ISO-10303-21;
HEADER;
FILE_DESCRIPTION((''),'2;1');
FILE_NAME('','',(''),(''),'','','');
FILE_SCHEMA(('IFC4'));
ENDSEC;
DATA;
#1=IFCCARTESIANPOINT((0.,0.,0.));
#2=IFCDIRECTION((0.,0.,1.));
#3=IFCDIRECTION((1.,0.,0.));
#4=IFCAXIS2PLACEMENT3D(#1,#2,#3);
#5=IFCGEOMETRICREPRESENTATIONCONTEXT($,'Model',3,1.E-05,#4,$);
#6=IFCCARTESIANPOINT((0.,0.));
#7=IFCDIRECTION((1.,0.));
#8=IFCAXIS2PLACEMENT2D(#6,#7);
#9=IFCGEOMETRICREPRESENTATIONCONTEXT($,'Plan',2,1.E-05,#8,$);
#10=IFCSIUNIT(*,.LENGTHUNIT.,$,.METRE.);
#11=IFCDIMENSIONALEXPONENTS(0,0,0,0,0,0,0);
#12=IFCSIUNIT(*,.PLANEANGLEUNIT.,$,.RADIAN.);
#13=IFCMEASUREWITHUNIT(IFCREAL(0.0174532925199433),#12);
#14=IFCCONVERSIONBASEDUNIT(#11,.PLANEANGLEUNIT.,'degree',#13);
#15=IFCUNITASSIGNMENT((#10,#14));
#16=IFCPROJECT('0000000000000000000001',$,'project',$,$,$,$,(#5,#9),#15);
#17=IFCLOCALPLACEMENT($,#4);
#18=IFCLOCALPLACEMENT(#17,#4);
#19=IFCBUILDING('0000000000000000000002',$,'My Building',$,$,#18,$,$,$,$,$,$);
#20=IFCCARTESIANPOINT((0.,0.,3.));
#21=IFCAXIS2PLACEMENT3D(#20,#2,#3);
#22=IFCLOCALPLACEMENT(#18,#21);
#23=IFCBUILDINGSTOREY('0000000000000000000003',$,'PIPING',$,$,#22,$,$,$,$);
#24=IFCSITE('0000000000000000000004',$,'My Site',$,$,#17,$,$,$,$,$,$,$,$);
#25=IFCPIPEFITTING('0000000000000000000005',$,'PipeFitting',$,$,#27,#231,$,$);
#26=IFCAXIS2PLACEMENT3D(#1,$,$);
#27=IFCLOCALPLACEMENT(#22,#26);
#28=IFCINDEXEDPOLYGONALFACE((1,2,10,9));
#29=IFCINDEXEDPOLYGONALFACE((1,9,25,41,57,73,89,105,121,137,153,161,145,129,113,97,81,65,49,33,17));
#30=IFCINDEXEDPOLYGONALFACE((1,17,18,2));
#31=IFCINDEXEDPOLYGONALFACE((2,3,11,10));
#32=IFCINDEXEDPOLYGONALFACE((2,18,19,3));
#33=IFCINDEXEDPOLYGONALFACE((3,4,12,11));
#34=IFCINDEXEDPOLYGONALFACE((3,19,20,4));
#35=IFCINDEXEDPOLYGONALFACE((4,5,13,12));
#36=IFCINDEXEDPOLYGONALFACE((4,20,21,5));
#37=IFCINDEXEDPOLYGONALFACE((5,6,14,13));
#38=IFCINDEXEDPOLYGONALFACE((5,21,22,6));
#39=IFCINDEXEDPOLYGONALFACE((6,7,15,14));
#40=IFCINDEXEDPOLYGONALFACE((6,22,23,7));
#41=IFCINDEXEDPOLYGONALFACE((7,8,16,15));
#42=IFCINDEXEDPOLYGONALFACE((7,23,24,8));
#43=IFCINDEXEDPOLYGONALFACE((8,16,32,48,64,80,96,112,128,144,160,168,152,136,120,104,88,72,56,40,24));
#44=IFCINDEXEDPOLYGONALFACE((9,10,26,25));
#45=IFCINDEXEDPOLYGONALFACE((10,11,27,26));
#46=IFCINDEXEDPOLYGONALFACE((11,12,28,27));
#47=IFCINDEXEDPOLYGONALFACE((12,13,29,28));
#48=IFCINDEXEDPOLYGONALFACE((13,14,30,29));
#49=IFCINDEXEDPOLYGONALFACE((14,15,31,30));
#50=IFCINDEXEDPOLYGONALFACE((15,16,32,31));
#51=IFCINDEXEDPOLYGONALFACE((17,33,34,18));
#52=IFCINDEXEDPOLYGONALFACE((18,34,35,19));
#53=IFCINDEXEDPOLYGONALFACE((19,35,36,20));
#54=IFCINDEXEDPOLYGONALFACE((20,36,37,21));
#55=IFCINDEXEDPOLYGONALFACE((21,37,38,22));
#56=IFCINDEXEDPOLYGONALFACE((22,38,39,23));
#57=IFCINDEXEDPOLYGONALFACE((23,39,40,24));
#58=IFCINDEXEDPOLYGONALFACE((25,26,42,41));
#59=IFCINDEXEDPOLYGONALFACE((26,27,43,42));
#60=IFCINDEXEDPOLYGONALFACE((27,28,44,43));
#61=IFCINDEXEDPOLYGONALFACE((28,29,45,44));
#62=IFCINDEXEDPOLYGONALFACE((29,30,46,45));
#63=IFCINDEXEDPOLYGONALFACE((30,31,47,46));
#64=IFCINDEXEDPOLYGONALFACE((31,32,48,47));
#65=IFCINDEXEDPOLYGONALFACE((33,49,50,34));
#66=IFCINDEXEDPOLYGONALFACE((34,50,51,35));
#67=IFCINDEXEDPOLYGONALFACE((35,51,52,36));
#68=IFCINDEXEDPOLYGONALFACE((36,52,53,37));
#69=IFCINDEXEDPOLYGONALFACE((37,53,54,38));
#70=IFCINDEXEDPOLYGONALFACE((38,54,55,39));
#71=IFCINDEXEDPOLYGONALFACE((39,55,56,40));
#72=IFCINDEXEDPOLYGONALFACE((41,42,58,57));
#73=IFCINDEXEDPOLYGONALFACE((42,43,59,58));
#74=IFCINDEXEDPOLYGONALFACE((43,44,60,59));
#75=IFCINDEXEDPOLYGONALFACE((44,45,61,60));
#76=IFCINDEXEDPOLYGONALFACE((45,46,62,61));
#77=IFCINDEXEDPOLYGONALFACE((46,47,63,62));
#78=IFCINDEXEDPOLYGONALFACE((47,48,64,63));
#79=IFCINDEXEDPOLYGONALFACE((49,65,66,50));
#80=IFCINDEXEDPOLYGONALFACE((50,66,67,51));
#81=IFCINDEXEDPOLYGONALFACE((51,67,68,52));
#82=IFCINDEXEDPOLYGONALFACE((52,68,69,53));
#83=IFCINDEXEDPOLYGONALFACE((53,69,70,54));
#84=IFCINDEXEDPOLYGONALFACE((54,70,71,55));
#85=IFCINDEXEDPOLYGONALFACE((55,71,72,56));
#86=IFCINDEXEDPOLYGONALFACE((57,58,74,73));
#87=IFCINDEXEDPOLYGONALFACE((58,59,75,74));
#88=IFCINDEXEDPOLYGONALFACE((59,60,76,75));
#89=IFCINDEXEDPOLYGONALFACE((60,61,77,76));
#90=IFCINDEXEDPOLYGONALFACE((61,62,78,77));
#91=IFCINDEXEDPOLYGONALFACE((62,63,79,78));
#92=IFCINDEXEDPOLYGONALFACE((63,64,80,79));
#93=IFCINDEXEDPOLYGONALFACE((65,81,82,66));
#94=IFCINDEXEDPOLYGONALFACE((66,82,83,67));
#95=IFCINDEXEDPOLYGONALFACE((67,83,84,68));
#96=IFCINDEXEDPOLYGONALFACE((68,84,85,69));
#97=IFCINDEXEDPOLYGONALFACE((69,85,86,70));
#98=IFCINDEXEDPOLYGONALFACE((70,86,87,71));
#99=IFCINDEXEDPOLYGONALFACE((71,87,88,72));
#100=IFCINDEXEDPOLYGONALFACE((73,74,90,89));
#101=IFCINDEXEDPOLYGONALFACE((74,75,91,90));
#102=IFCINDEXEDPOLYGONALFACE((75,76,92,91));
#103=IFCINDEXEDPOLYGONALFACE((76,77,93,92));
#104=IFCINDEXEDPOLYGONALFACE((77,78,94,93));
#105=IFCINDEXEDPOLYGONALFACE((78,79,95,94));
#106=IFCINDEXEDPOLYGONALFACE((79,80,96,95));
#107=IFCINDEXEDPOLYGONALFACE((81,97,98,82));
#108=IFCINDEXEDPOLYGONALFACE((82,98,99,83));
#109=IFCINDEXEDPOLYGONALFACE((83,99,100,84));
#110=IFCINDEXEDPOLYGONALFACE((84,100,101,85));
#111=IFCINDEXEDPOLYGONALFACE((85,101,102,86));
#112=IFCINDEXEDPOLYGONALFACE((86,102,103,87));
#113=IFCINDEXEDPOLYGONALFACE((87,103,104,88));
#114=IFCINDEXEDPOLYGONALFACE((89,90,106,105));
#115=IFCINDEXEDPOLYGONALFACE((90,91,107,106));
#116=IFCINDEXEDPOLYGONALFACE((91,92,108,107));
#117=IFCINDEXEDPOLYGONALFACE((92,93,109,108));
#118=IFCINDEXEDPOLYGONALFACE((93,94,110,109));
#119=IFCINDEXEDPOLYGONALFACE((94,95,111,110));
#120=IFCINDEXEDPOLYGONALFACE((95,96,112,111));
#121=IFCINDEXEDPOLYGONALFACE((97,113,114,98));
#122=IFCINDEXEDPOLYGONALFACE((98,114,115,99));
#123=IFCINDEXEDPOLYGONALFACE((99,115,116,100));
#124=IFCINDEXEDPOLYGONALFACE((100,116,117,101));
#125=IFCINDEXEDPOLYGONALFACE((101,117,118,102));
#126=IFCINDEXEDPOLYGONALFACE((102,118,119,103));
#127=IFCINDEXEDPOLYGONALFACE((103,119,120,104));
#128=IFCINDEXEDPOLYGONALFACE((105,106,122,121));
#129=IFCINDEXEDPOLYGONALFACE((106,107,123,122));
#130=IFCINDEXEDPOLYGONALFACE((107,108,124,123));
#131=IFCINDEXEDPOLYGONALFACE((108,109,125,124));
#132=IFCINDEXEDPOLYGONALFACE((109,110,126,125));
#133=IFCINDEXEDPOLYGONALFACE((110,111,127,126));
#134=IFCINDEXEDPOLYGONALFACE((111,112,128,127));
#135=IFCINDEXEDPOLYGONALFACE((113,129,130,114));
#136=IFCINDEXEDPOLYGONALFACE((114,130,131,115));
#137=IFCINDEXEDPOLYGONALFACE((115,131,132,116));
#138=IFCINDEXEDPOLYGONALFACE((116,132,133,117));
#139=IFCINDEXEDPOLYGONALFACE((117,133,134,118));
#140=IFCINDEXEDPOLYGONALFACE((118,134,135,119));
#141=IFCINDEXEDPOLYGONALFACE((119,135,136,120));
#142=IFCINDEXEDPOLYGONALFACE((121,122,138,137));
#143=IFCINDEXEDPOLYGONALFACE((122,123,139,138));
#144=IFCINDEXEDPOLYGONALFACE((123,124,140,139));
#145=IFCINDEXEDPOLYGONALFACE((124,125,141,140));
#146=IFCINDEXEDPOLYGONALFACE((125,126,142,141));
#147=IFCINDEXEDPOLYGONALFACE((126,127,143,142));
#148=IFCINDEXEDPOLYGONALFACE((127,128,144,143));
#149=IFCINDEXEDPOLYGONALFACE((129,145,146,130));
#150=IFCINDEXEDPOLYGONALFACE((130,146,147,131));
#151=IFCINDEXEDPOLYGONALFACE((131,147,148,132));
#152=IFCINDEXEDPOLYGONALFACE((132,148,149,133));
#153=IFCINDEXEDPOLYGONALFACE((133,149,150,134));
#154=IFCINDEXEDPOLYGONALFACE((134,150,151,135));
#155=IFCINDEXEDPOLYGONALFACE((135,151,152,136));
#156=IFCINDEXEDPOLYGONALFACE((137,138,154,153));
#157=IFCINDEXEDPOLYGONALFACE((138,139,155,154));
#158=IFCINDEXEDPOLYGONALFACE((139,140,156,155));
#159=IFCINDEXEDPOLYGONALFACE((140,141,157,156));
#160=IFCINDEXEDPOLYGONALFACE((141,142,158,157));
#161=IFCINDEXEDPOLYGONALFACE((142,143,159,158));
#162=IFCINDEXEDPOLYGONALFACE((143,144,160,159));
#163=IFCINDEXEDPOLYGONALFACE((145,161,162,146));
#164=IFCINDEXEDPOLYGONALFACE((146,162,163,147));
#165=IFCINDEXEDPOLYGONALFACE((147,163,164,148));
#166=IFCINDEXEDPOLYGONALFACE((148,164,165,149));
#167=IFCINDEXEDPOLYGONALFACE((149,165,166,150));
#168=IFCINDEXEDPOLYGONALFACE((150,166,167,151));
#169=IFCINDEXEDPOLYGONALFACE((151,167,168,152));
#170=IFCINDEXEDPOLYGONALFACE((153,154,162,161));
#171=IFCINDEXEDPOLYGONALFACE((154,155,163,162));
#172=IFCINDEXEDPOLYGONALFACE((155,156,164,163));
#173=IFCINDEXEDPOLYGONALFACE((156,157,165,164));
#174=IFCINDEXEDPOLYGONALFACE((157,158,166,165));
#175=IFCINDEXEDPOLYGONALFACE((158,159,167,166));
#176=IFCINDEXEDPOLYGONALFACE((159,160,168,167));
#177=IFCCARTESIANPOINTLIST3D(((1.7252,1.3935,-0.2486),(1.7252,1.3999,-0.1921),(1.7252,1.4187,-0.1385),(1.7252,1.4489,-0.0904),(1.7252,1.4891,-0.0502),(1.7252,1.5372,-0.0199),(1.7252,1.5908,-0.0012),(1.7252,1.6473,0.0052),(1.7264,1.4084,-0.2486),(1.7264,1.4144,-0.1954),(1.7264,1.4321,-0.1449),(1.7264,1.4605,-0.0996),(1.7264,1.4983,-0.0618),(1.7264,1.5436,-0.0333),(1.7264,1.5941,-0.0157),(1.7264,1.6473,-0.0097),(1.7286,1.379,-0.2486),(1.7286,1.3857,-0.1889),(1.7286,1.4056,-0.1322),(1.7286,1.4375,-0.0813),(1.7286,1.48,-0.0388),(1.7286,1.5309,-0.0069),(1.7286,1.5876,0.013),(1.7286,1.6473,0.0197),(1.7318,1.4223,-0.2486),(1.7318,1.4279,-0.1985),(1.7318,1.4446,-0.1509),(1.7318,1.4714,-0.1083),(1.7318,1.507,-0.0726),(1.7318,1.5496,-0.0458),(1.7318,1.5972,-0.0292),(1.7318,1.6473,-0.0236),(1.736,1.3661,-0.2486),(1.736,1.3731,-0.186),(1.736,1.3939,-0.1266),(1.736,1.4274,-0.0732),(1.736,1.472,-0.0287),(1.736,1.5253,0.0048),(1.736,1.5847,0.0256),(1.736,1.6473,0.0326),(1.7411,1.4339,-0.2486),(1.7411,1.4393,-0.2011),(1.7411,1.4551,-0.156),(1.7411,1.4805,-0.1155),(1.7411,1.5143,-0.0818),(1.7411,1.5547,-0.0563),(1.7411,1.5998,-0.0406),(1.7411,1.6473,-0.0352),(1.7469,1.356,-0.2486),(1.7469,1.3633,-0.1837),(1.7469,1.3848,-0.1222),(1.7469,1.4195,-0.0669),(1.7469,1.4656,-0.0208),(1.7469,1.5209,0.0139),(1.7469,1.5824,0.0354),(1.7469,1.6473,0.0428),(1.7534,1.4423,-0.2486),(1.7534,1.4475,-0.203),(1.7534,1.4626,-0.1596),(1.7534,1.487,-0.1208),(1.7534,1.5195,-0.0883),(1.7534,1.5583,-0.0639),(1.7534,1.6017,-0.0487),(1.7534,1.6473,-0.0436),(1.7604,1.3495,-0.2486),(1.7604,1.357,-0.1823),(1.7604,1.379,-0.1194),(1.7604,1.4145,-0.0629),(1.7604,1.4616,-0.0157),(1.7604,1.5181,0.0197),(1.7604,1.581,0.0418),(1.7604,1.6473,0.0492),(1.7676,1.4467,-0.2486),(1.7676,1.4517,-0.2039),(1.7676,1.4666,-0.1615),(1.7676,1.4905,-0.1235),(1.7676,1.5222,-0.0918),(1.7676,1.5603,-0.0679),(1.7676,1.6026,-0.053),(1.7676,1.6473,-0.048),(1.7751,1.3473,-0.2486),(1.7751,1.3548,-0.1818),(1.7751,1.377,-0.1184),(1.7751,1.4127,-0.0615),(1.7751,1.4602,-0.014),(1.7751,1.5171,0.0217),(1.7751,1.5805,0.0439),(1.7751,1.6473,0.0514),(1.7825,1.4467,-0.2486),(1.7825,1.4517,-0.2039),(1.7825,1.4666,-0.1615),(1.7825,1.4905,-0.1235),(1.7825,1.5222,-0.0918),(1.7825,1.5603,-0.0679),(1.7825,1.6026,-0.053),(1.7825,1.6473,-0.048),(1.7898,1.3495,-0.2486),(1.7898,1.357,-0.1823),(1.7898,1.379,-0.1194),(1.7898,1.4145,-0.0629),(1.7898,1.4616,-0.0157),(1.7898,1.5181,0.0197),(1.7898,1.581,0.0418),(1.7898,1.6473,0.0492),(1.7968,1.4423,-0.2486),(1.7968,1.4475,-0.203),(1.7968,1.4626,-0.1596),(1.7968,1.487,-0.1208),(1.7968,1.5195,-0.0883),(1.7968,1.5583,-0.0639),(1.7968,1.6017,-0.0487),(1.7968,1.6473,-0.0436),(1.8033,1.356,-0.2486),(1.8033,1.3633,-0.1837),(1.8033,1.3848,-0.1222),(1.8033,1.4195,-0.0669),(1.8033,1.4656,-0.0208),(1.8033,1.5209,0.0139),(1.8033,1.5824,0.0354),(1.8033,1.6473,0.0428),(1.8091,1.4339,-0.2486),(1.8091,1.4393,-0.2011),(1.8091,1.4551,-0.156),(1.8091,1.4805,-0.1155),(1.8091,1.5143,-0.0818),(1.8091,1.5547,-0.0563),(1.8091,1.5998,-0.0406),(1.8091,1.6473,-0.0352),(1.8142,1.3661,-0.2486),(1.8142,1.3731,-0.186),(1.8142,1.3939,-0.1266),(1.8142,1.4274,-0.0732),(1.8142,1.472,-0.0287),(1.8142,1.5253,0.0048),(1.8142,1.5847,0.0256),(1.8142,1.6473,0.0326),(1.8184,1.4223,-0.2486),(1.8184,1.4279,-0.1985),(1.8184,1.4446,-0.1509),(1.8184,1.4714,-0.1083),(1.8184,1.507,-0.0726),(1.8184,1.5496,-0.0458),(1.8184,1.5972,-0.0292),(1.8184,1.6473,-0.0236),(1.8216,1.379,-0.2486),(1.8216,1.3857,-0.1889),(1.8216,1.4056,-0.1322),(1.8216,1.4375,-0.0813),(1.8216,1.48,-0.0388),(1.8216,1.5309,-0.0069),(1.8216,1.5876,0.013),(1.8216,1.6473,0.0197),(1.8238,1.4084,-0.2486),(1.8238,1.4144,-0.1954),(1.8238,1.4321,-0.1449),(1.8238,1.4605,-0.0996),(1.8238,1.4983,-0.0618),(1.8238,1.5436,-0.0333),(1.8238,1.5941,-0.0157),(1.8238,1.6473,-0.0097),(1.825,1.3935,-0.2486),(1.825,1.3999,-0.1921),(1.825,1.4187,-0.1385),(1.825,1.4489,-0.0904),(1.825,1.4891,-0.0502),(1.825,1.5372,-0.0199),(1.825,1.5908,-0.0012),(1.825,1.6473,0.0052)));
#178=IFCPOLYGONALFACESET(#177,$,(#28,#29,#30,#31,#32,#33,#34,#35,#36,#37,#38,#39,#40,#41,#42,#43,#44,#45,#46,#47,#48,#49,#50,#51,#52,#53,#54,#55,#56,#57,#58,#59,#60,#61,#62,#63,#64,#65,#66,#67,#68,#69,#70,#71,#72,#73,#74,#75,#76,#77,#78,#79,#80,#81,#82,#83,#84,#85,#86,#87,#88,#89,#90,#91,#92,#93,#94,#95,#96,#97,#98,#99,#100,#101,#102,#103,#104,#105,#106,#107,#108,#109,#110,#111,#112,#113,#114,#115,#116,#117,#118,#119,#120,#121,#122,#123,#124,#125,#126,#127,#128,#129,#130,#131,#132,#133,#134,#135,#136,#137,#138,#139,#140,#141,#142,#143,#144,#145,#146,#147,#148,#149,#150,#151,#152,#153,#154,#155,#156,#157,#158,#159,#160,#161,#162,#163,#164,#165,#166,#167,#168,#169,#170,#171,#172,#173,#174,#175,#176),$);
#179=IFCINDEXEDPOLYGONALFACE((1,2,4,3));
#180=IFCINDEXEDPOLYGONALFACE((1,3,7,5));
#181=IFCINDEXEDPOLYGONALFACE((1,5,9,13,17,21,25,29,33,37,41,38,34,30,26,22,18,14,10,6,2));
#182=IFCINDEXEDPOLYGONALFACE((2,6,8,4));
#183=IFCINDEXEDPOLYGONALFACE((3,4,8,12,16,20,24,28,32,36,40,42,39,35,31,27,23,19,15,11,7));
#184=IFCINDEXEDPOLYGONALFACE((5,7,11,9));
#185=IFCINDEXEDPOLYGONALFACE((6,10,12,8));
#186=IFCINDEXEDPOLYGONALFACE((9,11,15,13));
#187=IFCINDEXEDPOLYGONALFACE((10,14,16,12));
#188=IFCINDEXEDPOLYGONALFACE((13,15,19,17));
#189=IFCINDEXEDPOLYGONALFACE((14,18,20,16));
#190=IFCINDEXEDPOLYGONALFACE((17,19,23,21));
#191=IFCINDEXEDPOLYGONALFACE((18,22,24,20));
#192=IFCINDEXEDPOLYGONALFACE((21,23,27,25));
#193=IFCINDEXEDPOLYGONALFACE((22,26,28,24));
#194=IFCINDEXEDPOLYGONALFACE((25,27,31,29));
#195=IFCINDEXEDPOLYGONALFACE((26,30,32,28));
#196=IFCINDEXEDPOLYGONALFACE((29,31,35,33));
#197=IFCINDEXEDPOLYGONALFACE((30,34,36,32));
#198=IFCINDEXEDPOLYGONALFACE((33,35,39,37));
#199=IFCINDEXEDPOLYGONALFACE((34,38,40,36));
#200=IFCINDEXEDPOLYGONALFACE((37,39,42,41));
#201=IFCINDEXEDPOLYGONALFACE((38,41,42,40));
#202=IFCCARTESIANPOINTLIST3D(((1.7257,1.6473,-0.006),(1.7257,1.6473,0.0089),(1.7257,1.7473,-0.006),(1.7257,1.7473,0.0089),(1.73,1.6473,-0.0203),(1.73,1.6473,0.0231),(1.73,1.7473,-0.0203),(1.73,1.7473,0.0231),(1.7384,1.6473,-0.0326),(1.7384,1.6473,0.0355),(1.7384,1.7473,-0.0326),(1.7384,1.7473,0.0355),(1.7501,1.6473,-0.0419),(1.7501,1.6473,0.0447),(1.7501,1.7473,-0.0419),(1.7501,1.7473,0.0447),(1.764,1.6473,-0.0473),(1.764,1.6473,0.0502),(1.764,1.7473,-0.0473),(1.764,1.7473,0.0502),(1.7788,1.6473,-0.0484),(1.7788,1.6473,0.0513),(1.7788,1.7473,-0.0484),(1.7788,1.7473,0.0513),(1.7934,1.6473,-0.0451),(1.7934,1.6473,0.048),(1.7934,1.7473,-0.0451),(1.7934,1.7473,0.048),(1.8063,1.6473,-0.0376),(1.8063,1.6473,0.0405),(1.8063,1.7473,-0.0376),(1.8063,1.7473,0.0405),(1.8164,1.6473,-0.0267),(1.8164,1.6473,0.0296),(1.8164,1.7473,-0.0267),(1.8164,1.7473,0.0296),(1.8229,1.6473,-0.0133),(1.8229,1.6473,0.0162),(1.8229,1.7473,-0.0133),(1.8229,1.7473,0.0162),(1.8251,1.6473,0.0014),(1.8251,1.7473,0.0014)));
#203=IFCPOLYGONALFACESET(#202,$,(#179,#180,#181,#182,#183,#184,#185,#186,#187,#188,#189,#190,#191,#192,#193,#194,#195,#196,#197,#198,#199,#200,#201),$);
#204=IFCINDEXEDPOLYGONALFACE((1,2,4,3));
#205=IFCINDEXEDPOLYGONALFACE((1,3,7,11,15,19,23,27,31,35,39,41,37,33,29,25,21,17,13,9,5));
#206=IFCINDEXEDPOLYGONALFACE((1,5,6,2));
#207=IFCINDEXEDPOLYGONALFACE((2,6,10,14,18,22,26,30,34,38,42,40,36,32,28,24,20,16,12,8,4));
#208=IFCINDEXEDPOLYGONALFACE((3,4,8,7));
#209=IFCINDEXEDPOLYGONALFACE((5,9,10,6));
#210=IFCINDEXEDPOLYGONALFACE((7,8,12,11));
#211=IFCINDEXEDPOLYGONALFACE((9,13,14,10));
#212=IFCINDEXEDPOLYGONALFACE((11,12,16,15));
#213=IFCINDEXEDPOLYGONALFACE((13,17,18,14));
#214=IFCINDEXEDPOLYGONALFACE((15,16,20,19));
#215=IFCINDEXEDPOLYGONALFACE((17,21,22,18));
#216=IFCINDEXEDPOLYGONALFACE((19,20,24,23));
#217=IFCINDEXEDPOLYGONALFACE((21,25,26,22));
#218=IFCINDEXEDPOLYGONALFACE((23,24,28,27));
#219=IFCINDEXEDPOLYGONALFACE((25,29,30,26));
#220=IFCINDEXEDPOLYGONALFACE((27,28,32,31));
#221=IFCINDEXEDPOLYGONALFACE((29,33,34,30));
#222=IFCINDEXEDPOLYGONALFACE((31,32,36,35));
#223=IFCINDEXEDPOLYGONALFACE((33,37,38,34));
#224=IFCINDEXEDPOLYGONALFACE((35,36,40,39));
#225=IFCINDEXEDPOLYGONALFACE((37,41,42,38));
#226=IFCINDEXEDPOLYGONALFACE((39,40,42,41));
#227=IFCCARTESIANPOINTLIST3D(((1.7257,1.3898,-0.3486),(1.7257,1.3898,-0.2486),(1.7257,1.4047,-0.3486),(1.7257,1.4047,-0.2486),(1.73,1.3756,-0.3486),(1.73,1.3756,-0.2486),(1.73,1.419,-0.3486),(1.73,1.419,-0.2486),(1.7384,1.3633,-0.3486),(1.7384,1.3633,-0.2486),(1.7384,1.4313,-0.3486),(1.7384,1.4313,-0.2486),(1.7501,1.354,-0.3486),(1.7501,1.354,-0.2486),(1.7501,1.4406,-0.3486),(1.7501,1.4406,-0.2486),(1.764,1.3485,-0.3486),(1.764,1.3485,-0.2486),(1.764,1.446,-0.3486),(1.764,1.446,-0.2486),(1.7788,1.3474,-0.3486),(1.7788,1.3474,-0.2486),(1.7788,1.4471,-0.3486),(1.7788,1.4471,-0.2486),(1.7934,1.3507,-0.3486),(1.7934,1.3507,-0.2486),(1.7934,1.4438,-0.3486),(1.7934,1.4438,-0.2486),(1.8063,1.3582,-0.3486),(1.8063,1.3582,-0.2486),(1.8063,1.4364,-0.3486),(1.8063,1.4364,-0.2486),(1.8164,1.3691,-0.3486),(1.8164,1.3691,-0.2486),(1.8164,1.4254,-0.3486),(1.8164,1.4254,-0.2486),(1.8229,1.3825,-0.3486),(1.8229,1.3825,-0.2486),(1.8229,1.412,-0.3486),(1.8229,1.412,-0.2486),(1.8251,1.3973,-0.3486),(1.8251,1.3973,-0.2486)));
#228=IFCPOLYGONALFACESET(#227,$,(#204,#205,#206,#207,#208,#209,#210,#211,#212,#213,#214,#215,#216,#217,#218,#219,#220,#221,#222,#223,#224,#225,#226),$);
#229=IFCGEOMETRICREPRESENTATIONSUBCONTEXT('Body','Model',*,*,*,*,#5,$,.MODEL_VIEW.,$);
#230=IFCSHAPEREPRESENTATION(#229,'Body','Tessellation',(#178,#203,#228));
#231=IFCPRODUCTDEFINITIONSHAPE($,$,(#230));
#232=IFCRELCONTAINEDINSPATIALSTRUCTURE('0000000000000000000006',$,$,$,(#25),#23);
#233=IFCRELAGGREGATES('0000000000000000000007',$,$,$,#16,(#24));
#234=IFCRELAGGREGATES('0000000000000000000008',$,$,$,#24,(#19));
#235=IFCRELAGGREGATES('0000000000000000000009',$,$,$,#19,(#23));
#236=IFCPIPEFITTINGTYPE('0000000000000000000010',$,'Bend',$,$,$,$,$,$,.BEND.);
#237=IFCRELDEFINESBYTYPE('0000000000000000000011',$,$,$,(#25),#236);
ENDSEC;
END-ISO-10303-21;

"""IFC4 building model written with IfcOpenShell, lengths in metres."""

from ifc_helpers import new_model, entity, si_unit, converted_unit, frame, origin_with_axes, origin_2d_with_axis, place, context, subcontext, project, spatial, circle, extrude, source, transform, mapped, type_object, type_shapes, element, save


model = new_model("IFC4")

# Units and contexts
model_context = context("Model", 3, precision=1e-05, world=origin_with_axes())
plan_context = context("Plan", 2, precision=1e-05, world=origin_2d_with_axis())
body_context = subcontext(model_context, "Body", "Model", "MODEL_VIEW")
ifc_project = project(units=[si_unit("LENGTHUNIT", "METRE"), converted_unit("PLANEANGLEUNIT", "degree", entity("IfcReal", 0.0174532925199433), si_unit("PLANEANGLEUNIT", "RADIAN"), dimensions=[0, 0, 0, 0, 0, 0, 0])], contexts=[model_context, plan_context])

# Site, building, storey
site_placement = place(None, origin_with_axes())
site = spatial("IfcSite", under=ifc_project, at=site_placement, Name="My Site")
building_placement = place(site_placement, origin_with_axes())
building = spatial("IfcBuilding", under=site, at=building_placement, Name="My Building")
storey_placement = place(building_placement, frame((0.0, 0.0, 3.0), z_axis=(0.0, 0.0, 1.0), x_axis=(1.0, 0.0, 0.0)))
storey = spatial("IfcBuildingStorey", under=building, at=storey_placement, Name="PIPING")

# Pipe fitting
pipe_fitting_type = type_object("IfcPipeFittingType", Name="Bend", PredefinedType="BEND")
shared_shape = source(origin_with_axes(), body_context, "Body", "SolidModel", [
    entity("IfcSweptDiskSolid", entity("IfcIndexedPolyCurve", entity("IfcCartesianPointList3D", [[0.0, 0.0, -0.1], [0.0, 0.0732, -0.2768], [0.0, 0.25, -0.35]]), [entity("IfcArcIndex", [1, 2, 3])]), 0.05),
    extrude(circle(Radius=0.05), origin_with_axes(), (0.0, 0.0, -1.0), 0.1),
    extrude(circle(Radius=0.05), frame((0.0, 0.25, -0.35), z_axis=(0.0, 1.0, 0.0), x_axis=(1.0, 0.0, 0.0)), (0.0, 0.0, 1.0), 0.1),
])
type_shapes(pipe_fitting_type, [shared_shape])
for number, where, z_axis, x_axis, name in (
    (1, (1.7751, 1.7473, 0.0014), (0.0, 1.0, 0.0), (1.0, 0.0, 0.0), "PipeFitting"),
):
    element("IfcPipeFitting", number, at=place(storey_placement, frame(where, z_axis=z_axis, x_axis=x_axis)), inside=storey, type_object=pipe_fitting_type, Name=name, context=body_context, shape_type="MappedRepresentation", body=[
        mapped(shared_shape, transform((0.0, 0.0, 0.0), x_axis=(1.0, 0.0, 0.0), y_axis=(0.0, 1.0, 0.0), z_axis=(0.0, 0.0, 1.0), scale=1.0)),
    ])

save(model, "model.ifc")
